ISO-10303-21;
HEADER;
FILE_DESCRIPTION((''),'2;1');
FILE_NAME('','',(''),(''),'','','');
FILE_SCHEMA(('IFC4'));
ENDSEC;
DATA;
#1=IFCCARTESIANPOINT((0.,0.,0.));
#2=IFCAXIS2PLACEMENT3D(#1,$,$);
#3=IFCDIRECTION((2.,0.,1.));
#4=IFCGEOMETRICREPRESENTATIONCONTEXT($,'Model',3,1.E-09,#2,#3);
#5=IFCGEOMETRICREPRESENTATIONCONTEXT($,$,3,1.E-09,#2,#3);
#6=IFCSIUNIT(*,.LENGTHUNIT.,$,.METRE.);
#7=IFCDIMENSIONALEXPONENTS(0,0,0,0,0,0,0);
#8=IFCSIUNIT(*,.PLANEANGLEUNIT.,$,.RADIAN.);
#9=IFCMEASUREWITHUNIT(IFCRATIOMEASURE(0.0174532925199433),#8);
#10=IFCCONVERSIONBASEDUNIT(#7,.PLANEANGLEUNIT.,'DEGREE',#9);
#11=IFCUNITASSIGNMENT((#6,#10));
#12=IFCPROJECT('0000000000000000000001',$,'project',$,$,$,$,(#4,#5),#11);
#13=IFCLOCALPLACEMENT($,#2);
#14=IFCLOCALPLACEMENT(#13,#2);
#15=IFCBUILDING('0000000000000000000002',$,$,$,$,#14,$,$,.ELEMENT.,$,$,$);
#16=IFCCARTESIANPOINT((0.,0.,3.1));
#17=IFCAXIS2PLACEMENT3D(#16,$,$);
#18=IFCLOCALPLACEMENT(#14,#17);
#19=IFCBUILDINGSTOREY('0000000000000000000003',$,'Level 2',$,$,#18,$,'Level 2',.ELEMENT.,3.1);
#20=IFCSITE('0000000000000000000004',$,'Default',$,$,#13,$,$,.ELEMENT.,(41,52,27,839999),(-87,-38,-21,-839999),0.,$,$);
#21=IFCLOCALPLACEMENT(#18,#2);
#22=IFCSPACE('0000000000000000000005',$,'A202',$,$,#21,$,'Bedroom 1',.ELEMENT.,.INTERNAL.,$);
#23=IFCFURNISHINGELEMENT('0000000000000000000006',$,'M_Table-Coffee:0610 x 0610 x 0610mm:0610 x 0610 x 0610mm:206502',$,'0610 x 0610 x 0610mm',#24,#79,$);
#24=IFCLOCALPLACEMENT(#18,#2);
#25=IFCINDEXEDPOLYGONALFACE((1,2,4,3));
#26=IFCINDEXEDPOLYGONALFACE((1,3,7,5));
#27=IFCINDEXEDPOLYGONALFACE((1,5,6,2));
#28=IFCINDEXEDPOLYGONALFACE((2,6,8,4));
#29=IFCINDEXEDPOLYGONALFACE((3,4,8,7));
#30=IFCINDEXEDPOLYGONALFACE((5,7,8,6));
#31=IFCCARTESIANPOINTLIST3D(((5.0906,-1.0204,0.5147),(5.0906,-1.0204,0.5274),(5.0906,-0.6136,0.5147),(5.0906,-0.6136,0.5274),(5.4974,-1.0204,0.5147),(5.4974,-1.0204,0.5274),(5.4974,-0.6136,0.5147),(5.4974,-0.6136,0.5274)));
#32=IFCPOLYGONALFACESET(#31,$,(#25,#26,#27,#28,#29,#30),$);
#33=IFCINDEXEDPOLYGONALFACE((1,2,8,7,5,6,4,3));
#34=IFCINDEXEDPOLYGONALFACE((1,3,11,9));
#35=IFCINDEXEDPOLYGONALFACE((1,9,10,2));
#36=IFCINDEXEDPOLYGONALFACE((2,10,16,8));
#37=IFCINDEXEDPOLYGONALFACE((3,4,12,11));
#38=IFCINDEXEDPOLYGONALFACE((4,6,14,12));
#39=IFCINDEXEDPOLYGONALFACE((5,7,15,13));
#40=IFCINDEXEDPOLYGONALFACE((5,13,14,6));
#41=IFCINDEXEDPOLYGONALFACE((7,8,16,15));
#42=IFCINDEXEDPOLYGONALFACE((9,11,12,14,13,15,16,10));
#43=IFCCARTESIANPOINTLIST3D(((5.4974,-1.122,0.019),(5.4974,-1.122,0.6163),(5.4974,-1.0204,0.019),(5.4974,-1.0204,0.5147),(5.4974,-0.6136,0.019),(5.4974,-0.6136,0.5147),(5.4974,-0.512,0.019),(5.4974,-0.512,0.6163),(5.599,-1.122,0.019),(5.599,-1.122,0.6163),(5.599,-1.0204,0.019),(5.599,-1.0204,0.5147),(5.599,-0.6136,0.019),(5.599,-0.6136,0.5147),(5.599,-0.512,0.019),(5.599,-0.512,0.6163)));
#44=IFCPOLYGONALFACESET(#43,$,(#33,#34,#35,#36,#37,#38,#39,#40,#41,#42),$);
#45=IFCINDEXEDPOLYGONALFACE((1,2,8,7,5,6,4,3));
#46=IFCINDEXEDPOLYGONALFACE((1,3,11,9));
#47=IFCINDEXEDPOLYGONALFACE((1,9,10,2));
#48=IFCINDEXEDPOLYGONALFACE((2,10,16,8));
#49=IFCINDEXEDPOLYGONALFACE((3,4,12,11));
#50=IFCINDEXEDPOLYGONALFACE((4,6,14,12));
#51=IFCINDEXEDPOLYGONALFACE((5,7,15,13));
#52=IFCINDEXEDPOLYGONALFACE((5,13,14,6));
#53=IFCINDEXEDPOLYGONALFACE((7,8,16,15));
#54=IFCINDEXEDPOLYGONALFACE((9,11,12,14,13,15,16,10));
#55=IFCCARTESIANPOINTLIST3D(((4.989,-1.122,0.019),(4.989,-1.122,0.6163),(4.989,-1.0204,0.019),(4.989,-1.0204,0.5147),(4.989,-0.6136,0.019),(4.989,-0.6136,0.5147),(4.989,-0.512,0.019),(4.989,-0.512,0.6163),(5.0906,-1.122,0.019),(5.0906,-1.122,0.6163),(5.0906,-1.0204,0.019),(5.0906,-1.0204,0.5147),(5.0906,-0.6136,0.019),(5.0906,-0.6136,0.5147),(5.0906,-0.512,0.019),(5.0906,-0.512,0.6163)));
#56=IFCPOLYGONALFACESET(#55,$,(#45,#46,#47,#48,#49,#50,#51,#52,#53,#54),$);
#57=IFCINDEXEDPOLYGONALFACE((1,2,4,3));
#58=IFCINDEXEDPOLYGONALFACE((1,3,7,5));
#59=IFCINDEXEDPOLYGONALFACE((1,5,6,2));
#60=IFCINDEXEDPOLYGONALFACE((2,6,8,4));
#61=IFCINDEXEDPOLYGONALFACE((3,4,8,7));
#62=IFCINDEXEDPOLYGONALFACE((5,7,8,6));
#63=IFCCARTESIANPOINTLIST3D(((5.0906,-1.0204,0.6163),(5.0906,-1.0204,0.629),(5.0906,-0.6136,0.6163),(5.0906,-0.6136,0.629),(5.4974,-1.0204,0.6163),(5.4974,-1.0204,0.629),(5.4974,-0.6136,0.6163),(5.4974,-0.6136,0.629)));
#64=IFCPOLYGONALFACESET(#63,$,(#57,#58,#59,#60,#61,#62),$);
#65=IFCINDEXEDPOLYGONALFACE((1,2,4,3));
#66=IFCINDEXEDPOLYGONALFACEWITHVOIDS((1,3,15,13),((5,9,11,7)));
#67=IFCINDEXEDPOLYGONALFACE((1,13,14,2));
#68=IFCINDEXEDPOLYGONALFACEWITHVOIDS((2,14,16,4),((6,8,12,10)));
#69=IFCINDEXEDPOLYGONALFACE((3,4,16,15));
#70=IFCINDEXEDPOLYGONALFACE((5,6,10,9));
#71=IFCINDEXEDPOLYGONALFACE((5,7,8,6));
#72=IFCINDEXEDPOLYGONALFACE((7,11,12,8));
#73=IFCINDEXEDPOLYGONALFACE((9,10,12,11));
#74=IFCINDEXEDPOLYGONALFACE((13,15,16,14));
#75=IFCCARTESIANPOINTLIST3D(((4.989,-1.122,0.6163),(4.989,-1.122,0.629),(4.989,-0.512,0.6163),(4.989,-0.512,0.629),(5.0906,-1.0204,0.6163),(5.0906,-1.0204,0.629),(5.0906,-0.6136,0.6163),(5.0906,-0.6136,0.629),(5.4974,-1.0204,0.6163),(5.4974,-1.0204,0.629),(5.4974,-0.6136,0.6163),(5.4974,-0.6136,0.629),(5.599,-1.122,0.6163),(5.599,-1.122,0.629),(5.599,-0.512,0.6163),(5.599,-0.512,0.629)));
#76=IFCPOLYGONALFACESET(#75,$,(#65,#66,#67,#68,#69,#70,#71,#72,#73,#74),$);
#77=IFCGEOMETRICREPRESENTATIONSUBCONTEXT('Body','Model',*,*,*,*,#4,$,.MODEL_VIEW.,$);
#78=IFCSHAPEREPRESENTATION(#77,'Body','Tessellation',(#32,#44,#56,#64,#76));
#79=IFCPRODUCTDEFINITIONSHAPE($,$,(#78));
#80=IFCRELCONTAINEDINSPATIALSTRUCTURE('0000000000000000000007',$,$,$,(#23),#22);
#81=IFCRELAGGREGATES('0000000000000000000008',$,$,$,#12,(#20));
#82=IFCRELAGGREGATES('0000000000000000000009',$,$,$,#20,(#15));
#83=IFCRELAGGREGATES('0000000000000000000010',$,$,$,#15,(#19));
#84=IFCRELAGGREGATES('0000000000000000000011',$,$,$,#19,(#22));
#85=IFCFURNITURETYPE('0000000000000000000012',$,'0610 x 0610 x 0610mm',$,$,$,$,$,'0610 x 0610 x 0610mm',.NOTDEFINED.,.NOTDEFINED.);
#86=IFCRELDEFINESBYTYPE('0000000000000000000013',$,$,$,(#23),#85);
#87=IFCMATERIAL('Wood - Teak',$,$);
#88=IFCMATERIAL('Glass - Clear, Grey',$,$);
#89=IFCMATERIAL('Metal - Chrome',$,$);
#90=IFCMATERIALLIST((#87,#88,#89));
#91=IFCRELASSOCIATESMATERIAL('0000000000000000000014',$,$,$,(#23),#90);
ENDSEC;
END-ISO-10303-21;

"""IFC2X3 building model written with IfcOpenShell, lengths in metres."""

from ifc_helpers import new_model, entity, si_unit, converted_unit, direction, frame, origin, origin_2d_with_axis, place, context, subcontext, project, spatial, polyline, rectangle, outline, extrude, source, transform, mapped, material, material_list, type_object, type_shapes, element, save


model = new_model("IFC2X3")

# Units and contexts
model_context = context("Model", 3, precision=1e-09, world=origin(), true_north=direction((2.0, 0.0, 1.0)))
context_of_model = context(None, 3, precision=1e-09, world=origin(), true_north=direction((2.0, 0.0, 1.0)))
body_context = subcontext(model_context, "Body", "Model", "MODEL_VIEW")
ifc_project = project(units=[si_unit("LENGTHUNIT", "METRE"), converted_unit("PLANEANGLEUNIT", "DEGREE", entity("IfcRatioMeasure", 0.0174532925199433), si_unit("PLANEANGLEUNIT", "RADIAN"), dimensions=[0, 0, 0, 0, 0, 0, 0])], contexts=[model_context, context_of_model])

# Site, building, storey
site_placement = place(None, origin())
site = spatial("IfcSite", under=ifc_project, at=site_placement, Name="Default", CompositionType="ELEMENT", RefLatitude=(41, 52, 27, 839999), RefLongitude=(-87, -38, -21, -839999), RefElevation=0.0)
building_placement = place(site_placement, origin())
building = spatial("IfcBuilding", under=site, at=building_placement, CompositionType="ELEMENT")
storey_placement = place(building_placement, frame((0.0, 0.0, 3.1)))
storey = spatial("IfcBuildingStorey", under=building, at=storey_placement, Name="Level 2", LongName="Level 2", CompositionType="ELEMENT", Elevation=3.1)

# Shared definitions
ifc_material_1 = material(Name="Wood - Teak")
ifc_material_2 = material(Name="Glass - Clear, Grey")
ifc_material_3 = material(Name="Metal - Chrome")
furniture_type_1 = type_object("IfcFurnitureType", Name="0610 x 0610 x 0610mm", ElementType="0610 x 0610 x 0610mm", AssemblyPlace="NOTDEFINED")
shared_shape_1 = source(origin(), body_context, "Body", "SweptSolid", [
    extrude(rectangle(XDim=0.4068, YDim=0.4068, at=origin_2d_with_axis()), frame((0.0183, 0.0952, 0.4957), z_axis=(0.0, 0.0, 1.0), x_axis=(-1.0, 0.0, 0.0)), (0.0, 0.0, 1.0), 0.0127),
    extrude(outline(polyline([(-0.2732, -0.305), (0.324, -0.305), (0.324, 0.305), (-0.2732, 0.305), (-0.2732, 0.2034), (0.2225, 0.2034), (0.2225, -0.2034), (-0.2732, -0.2034), (-0.2732, -0.305)])), frame((0.2217, 0.0952, 0.2732), z_axis=(1.0, 0.0, 0.0), x_axis=(0.0, 0.0, 1.0)), (0.0, 0.0, 1.0), 0.1016),
    extrude(outline(polyline([(-0.305, -0.3241), (0.305, -0.3241), (0.305, 0.2733), (0.2034, 0.2733), (0.2034, -0.2224), (-0.2034, -0.2224), (-0.2034, 0.2733), (-0.305, 0.2733), (-0.305, -0.3241)])), frame((-0.2867, 0.0952, 0.2733), z_axis=(1.0, 0.0, 0.0), x_axis=(0.0, -1.0, 0.0)), (0.0, 0.0, 1.0), 0.1016),
    extrude(rectangle(XDim=0.4068, YDim=0.4068, at=origin_2d_with_axis()), frame((0.0183, 0.0952, 0.5973), z_axis=(0.0, 0.0, 1.0), x_axis=(-1.0, 0.0, 0.0)), (0.0, 0.0, 1.0), 0.0127),
    extrude(outline(polyline([(-0.305, -0.305), (0.305, -0.305), (0.305, 0.305), (-0.305, 0.305), (-0.305, -0.305)]), holes=[polyline([(-0.2034, -0.2034), (-0.2034, 0.2034), (0.2034, 0.2034), (0.2034, -0.2034), (-0.2034, -0.2034)])]), frame((0.0183, 0.0952, 0.5973), z_axis=(0.0, 0.0, 1.0), x_axis=(-1.0, 0.0, 0.0)), (0.0, 0.0, 1.0), 0.0127),
])
type_shapes(furniture_type_1, [shared_shape_1])

# Shared definitions
space_1_placement = place(storey_placement, origin())
space_1 = spatial("IfcSpace", under=storey, at=space_1_placement, Name="A202", LongName="Bedroom 1", CompositionType="ELEMENT", InteriorOrExteriorSpace="INTERNAL")

# Furnishing element
ifc_material_list_1 = material_list([ifc_material_1, ifc_material_2, ifc_material_3])
furnishing_1_placement = place(space_1_placement, frame((5.2757, -0.9122, 0.019)))
element("IfcFurnishingElement", 1, at=furnishing_1_placement, inside=space_1, type_object=furniture_type_1, material=ifc_material_list_1, Name="M_Table-Coffee:0610 x 0610 x 0610mm:0610 x 0610 x 0610mm:206502", ObjectType="0610 x 0610 x 0610mm", context=body_context, shape_type="MappedRepresentation", body=[
    mapped(shared_shape_1, transform((0.0, 0.0, 0.0), scale=1.0)),
])

save(model, "model.ifc")
